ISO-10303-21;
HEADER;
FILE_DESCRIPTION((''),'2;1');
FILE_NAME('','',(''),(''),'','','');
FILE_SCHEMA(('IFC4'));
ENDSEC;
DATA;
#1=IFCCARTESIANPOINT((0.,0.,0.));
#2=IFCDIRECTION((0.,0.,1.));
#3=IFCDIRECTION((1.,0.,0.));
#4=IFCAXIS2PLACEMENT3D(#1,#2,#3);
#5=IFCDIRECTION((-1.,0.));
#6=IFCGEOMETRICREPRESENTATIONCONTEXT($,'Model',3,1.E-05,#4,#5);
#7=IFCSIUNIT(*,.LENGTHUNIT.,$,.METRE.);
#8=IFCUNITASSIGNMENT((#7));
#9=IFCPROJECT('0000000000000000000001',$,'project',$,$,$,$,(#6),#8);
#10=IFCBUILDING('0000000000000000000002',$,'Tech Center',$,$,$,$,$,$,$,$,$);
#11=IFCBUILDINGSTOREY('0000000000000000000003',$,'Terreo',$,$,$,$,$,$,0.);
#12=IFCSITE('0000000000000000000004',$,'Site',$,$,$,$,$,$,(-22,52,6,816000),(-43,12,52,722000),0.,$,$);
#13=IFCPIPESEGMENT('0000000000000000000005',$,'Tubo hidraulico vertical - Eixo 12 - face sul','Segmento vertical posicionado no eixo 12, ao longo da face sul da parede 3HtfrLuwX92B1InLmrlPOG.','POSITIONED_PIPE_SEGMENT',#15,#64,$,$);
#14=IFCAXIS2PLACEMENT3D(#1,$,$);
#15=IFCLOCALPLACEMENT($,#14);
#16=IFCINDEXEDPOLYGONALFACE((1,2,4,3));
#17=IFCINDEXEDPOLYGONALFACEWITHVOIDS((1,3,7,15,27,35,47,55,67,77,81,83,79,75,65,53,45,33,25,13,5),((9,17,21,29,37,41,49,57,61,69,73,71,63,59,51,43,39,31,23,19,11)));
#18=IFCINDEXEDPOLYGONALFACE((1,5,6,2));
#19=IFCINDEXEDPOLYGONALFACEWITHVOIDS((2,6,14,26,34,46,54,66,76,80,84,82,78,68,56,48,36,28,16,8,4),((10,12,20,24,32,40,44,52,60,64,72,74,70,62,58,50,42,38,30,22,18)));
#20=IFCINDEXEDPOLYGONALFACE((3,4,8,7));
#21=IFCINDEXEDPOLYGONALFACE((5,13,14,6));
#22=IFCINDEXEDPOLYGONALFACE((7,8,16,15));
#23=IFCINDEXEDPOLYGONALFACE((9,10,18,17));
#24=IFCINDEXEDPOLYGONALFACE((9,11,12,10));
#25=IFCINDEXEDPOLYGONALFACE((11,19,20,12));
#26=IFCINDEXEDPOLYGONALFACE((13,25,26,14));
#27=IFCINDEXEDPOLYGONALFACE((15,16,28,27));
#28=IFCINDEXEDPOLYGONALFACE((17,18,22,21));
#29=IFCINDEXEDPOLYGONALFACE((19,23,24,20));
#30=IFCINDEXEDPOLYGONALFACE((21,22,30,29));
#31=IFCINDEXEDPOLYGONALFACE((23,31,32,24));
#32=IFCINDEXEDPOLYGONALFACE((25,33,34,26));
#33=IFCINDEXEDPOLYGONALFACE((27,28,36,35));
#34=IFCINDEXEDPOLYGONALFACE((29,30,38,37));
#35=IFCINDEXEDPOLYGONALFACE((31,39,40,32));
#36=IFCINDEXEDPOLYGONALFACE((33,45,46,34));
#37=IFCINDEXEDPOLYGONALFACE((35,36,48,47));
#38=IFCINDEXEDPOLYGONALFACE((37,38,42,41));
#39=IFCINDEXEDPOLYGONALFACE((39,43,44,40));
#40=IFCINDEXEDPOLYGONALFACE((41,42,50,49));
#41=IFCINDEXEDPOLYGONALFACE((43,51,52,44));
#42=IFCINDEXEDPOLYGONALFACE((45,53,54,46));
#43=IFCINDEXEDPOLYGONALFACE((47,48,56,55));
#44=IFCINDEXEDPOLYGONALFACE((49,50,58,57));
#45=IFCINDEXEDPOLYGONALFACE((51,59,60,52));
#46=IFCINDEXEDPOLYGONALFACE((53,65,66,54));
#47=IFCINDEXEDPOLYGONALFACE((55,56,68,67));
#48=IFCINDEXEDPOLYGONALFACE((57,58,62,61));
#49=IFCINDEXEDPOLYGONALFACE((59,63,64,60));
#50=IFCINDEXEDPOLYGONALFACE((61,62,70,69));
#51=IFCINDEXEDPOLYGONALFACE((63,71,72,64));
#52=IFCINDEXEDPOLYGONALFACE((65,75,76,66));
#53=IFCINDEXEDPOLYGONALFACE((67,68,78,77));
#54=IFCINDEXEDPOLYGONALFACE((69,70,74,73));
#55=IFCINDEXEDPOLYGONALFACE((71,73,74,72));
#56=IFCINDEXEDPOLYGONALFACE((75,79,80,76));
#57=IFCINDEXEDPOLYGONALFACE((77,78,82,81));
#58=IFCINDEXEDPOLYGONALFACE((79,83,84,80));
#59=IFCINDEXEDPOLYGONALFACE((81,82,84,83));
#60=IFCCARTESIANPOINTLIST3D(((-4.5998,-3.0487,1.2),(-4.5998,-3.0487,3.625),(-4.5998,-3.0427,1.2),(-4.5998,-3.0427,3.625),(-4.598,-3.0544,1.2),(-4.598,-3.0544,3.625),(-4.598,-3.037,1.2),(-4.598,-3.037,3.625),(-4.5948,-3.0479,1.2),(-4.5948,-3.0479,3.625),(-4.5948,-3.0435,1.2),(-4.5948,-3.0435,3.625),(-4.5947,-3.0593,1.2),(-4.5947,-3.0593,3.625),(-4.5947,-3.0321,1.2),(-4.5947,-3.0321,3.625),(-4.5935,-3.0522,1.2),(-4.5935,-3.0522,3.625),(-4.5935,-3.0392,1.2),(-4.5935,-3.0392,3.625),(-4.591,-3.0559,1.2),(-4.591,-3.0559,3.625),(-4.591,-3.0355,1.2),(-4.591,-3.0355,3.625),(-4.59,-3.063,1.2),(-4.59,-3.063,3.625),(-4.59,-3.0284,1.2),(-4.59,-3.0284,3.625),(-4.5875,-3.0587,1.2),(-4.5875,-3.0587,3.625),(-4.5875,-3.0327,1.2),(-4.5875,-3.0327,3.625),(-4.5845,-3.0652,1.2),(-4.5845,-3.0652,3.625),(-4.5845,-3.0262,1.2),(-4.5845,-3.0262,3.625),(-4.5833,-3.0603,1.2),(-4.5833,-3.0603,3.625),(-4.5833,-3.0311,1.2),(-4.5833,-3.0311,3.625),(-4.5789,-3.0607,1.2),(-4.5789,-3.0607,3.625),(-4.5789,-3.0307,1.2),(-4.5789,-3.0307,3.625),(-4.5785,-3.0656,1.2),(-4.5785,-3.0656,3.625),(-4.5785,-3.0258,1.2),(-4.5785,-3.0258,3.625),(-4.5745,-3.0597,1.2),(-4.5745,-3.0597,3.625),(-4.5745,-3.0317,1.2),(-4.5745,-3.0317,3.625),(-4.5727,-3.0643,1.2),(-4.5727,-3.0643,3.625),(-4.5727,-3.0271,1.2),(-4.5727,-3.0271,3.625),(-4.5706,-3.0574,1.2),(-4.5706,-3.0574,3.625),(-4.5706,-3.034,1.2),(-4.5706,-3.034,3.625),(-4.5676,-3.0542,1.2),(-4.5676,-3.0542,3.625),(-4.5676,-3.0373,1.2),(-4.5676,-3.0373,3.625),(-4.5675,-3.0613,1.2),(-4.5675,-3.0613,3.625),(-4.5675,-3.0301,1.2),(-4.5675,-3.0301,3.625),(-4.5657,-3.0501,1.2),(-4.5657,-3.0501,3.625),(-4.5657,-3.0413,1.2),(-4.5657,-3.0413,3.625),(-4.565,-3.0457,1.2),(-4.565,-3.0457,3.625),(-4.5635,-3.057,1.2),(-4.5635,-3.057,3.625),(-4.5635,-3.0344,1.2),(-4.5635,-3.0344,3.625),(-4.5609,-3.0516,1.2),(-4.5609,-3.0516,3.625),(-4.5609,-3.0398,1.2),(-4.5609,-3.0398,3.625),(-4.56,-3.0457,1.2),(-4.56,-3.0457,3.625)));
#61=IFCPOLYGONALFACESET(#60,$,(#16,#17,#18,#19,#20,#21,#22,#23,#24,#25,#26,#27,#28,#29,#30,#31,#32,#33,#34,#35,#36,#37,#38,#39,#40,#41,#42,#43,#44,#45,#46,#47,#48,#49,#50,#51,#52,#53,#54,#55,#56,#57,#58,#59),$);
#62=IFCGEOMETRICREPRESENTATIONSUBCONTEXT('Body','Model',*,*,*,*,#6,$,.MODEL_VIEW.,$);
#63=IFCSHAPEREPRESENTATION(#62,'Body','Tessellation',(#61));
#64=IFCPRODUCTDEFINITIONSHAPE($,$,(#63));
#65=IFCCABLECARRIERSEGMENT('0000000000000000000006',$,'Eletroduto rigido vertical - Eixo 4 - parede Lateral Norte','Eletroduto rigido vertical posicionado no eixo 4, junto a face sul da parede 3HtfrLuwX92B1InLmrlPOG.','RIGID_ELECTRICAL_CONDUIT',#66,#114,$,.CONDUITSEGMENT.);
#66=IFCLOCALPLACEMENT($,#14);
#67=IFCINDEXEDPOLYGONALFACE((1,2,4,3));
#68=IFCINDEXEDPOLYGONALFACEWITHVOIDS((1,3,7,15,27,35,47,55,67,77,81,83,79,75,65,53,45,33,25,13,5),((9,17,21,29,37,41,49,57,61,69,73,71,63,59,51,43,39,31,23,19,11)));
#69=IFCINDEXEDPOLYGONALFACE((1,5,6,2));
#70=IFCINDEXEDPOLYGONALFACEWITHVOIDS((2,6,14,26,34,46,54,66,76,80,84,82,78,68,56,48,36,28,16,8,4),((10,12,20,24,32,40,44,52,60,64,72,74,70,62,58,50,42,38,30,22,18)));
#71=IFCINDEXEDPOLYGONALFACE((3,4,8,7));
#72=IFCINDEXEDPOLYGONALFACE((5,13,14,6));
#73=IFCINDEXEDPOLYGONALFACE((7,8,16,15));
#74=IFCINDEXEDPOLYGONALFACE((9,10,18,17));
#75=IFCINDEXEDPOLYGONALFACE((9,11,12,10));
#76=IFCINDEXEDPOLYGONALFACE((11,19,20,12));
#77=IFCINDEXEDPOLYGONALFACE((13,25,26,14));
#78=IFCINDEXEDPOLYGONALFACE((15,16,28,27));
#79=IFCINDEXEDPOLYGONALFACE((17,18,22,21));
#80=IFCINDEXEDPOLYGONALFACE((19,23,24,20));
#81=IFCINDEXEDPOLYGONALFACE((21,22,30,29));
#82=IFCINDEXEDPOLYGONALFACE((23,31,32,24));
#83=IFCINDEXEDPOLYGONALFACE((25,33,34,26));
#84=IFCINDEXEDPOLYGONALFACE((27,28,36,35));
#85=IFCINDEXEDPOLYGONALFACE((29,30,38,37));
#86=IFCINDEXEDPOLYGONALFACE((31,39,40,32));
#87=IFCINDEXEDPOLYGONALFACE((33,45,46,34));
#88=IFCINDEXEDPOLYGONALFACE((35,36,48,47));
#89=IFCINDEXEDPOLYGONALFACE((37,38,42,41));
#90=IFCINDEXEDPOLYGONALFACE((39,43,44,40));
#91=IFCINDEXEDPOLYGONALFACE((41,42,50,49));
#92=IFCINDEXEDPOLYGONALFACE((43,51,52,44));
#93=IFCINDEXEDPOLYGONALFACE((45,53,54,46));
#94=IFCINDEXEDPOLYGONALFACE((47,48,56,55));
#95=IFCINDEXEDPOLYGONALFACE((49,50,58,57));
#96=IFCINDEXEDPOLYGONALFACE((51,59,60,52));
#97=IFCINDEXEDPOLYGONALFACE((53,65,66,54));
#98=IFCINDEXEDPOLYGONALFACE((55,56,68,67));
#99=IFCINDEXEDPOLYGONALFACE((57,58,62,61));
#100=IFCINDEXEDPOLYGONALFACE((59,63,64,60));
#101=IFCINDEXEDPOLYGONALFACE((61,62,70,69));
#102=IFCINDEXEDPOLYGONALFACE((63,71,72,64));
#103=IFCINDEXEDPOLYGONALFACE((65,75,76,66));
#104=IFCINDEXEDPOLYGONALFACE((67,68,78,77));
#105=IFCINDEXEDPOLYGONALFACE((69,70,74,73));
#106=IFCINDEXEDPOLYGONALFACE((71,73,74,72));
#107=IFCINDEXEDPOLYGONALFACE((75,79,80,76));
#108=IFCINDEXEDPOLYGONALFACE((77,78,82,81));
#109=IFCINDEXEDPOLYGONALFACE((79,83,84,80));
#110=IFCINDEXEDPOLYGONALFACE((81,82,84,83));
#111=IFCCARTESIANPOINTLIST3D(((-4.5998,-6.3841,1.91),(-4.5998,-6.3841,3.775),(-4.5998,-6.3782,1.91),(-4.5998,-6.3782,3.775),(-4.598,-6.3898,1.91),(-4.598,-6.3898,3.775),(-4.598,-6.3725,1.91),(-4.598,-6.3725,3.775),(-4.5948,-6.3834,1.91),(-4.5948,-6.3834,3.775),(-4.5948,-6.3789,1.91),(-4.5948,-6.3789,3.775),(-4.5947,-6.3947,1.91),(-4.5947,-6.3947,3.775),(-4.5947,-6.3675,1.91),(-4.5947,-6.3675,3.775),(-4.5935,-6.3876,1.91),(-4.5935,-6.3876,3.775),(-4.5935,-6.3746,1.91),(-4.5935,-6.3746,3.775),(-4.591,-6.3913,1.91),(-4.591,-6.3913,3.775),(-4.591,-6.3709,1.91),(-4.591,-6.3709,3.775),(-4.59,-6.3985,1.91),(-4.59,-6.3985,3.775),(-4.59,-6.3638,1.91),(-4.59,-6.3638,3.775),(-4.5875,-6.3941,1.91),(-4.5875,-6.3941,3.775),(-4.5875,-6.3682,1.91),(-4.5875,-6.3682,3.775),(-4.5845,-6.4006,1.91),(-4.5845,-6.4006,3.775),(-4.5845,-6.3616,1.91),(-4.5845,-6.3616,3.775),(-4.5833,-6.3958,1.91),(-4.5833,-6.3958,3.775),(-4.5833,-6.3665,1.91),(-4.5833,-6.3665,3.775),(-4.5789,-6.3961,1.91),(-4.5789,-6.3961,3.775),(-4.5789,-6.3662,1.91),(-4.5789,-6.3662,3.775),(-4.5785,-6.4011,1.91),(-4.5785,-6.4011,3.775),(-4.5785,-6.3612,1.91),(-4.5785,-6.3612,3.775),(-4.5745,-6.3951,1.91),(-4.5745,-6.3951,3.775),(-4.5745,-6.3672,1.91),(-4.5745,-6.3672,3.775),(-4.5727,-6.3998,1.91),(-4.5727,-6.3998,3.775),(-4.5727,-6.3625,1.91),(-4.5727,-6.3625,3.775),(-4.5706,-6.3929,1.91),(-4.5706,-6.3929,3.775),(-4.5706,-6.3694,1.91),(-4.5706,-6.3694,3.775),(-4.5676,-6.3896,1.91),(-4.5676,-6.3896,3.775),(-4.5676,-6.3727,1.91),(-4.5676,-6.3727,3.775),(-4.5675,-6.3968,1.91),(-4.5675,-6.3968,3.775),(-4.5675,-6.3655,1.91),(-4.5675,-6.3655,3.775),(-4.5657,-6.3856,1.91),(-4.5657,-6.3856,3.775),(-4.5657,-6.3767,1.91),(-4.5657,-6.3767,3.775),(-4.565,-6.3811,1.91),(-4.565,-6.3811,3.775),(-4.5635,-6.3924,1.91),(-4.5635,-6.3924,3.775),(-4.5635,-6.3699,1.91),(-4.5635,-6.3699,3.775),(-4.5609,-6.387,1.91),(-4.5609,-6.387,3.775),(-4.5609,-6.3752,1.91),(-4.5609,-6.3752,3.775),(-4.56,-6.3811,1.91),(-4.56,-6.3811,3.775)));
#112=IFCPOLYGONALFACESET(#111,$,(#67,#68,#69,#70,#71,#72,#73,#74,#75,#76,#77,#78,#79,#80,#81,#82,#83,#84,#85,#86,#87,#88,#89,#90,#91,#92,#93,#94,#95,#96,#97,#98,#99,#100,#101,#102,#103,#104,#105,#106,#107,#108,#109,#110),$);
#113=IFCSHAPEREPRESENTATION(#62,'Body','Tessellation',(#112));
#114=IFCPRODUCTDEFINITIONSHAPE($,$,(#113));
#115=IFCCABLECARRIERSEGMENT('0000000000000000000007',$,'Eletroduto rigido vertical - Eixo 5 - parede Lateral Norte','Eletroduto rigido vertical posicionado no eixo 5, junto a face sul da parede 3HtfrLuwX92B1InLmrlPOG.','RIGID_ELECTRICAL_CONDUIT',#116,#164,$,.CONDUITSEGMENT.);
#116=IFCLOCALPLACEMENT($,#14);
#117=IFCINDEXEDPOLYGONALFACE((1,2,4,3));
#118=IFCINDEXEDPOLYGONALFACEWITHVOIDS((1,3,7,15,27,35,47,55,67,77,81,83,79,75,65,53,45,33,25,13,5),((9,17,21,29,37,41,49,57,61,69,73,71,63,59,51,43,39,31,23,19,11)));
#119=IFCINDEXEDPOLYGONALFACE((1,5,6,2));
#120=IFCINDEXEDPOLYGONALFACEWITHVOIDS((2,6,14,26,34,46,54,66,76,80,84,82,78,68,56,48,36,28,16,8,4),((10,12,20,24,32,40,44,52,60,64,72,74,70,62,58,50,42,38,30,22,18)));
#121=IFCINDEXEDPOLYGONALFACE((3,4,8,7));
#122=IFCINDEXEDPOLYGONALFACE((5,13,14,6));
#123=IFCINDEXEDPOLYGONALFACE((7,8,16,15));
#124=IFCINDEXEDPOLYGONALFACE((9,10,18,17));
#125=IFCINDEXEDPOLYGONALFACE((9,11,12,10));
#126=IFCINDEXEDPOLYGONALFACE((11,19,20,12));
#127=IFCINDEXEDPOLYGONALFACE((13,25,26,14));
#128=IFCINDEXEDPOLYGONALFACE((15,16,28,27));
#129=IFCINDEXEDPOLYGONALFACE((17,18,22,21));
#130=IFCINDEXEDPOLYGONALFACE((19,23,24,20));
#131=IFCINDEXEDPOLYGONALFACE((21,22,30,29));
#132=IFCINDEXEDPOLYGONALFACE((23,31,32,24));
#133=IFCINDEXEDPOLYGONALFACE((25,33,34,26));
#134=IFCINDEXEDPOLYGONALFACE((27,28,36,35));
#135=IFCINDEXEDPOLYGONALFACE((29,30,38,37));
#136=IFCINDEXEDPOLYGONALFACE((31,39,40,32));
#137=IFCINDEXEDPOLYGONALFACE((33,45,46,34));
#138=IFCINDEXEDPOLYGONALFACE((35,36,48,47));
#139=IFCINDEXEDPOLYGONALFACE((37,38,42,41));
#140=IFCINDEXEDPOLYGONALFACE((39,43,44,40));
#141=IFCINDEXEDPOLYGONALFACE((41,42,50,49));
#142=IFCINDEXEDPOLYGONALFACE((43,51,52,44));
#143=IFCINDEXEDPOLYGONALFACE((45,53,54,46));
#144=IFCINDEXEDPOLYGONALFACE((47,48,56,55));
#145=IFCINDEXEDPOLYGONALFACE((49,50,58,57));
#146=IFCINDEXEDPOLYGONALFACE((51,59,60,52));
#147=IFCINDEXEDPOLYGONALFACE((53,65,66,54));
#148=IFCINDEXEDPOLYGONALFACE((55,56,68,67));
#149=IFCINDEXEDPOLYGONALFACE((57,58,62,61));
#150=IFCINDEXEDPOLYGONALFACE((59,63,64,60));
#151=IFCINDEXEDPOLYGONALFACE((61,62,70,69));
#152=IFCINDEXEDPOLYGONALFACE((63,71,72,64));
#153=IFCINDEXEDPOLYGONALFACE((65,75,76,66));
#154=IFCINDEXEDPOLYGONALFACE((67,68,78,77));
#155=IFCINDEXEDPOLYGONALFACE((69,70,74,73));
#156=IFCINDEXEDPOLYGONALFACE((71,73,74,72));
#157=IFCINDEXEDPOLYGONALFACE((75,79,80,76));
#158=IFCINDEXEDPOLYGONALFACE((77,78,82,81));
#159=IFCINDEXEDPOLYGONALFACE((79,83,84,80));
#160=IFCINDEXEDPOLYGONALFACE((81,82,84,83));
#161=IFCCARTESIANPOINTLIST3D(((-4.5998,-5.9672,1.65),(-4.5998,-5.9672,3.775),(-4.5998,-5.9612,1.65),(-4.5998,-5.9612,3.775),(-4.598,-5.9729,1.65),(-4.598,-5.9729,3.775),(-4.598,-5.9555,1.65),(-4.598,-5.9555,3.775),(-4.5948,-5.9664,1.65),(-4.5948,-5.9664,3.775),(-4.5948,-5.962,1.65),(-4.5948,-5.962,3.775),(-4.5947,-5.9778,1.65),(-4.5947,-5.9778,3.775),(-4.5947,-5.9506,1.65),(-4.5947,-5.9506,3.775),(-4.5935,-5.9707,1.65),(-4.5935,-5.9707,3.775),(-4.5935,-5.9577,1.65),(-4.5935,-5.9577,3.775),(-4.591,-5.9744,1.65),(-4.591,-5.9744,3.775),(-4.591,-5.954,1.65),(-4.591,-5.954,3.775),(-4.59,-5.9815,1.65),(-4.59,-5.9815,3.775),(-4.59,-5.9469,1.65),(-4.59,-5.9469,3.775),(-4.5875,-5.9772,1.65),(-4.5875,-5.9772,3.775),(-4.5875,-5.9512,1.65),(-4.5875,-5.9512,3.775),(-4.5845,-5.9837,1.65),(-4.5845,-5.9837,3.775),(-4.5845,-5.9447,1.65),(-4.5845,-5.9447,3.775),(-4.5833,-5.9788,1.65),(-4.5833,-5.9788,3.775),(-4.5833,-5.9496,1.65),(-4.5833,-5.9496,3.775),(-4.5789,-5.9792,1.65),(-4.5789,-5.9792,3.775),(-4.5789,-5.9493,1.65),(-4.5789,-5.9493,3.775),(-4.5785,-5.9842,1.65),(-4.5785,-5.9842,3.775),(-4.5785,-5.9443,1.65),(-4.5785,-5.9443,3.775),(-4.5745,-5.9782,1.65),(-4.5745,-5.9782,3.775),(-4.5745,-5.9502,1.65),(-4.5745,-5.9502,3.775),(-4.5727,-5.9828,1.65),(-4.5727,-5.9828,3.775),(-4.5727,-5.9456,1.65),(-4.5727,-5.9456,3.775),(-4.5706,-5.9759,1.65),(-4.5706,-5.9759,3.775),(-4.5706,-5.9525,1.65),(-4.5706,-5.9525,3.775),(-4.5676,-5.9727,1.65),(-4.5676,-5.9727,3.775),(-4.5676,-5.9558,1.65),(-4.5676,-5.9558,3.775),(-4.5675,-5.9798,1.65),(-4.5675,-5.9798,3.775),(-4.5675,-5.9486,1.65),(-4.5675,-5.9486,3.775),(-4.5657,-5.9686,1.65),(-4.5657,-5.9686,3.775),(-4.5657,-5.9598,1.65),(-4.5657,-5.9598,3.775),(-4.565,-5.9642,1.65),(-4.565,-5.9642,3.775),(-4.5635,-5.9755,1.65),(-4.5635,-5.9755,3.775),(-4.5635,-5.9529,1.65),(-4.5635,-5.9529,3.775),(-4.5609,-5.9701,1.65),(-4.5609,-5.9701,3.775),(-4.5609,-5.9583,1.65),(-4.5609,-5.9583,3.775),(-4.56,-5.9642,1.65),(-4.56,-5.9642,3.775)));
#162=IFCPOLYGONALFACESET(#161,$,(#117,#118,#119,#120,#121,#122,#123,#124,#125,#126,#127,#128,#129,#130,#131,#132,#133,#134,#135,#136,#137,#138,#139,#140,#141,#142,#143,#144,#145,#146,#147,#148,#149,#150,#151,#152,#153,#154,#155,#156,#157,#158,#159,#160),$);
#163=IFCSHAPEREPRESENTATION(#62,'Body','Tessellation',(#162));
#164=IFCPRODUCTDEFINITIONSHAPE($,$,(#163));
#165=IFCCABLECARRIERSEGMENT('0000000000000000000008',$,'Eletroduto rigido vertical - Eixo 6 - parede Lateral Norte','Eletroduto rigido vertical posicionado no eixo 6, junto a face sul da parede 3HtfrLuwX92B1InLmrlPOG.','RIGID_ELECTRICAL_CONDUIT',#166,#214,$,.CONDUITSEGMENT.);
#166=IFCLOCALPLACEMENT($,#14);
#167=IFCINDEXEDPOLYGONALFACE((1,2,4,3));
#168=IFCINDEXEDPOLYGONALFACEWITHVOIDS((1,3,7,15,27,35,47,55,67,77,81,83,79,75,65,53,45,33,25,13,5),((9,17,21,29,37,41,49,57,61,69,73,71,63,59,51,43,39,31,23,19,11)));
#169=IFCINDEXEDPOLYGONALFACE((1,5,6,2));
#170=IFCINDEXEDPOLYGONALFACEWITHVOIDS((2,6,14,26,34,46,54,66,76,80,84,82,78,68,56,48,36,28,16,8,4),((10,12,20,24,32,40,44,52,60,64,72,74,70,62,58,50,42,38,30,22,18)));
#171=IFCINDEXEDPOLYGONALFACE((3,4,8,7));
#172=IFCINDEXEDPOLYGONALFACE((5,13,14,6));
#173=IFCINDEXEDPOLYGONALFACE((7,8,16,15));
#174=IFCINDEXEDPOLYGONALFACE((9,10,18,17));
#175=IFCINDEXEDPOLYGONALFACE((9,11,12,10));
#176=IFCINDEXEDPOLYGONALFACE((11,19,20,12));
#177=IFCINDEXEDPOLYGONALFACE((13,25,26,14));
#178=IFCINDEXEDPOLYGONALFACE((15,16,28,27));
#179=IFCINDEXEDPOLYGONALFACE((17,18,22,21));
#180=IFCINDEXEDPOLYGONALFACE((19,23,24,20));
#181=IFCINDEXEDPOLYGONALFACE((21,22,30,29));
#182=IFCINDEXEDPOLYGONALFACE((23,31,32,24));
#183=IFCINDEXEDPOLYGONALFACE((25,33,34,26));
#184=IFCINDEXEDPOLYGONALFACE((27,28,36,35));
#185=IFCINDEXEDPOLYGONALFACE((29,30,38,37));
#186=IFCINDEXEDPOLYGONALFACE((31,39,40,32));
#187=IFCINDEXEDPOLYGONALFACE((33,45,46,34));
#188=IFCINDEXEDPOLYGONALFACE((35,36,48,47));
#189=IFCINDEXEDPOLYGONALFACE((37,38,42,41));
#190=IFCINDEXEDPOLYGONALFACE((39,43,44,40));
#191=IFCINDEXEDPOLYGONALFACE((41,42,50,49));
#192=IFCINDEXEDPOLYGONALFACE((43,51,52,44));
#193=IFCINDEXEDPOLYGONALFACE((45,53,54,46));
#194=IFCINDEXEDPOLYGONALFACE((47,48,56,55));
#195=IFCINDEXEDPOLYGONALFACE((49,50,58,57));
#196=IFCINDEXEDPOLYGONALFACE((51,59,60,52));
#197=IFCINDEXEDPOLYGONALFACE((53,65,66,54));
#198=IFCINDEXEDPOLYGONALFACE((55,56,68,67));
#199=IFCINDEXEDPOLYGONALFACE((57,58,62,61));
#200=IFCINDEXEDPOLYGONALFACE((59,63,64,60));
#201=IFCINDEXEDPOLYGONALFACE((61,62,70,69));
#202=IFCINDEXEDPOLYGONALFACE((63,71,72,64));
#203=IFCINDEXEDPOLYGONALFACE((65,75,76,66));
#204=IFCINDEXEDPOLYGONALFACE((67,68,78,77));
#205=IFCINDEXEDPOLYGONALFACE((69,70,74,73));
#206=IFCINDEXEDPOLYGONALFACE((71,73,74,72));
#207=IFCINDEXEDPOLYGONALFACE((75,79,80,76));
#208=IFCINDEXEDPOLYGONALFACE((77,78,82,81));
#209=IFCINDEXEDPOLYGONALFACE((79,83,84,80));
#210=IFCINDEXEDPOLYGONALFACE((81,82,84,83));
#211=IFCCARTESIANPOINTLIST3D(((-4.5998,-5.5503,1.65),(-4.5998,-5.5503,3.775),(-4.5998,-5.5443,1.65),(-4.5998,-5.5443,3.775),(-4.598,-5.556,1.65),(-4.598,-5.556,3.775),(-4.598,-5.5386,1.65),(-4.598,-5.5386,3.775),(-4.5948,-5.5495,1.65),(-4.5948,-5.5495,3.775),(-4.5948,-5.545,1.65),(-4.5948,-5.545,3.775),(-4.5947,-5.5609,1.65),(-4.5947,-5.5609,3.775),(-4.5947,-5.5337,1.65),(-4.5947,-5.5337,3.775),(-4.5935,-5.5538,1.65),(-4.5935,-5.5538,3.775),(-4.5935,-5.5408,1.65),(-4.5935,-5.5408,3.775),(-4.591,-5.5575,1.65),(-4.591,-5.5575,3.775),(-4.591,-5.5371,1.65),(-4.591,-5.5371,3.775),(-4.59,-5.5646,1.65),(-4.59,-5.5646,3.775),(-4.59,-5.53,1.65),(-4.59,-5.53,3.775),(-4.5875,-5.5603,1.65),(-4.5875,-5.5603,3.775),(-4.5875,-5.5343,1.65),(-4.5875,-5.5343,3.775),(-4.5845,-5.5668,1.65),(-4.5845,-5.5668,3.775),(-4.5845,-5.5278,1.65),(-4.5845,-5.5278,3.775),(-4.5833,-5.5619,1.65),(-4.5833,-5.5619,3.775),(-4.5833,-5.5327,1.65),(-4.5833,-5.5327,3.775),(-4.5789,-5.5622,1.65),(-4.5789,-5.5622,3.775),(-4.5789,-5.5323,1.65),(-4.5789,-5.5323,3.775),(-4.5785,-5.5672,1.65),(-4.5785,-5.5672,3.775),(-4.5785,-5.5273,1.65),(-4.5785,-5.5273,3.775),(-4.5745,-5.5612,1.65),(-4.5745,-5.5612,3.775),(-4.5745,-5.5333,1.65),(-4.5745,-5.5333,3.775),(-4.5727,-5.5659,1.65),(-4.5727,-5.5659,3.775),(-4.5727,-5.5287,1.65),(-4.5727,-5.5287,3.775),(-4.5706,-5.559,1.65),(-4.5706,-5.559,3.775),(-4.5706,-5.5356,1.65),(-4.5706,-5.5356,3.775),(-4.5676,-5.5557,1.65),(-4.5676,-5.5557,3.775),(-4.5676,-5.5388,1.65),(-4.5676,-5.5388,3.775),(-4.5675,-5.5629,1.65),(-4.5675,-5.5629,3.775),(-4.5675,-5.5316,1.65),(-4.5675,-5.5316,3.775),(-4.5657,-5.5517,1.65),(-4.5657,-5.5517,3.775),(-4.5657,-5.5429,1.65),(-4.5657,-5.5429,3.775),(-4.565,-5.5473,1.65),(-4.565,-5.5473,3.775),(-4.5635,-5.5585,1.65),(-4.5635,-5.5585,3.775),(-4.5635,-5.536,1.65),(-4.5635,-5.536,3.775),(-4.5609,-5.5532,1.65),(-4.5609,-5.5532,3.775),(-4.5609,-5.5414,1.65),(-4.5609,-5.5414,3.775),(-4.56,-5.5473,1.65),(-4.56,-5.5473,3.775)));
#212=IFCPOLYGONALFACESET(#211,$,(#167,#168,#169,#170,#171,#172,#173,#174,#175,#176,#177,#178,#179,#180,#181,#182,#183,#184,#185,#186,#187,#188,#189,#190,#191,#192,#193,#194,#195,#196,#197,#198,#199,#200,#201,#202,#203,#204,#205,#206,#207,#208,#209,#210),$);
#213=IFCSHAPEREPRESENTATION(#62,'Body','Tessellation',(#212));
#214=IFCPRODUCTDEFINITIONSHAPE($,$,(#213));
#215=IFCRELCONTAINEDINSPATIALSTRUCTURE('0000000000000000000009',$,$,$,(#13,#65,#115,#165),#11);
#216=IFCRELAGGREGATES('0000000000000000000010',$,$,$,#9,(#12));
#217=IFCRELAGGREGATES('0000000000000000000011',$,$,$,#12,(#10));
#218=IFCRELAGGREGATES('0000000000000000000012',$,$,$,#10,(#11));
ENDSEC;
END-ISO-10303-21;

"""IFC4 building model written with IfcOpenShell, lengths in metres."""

from ifc_helpers import new_model, si_unit, direction, frame, origin_with_axes, place, context, subcontext, project, spatial, hollow_circle, extrude, element, save


model = new_model("IFC4")

# Units and contexts
model_context = context("Model", 3, precision=1e-05, world=origin_with_axes(), true_north=direction((-1.0, 0.0)))
body_context = subcontext(model_context, "Body", "Model", "MODEL_VIEW")
ifc_project = project(units=[si_unit("LENGTHUNIT", "METRE")], contexts=[model_context])

# Site, building, storey
site = spatial("IfcSite", under=ifc_project, Name="Site", RefLatitude=(-22, 52, 6, 816000), RefLongitude=(-43, 12, 52, 722000), RefElevation=0.0)
building = spatial("IfcBuilding", under=site, Name="Tech Center")
storey = spatial("IfcBuildingStorey", under=building, Name="Terreo", Elevation=0.0)

# Pipe segment
for number, where, name in (
    (1, (-4.58, -3.0457, 1.2), "Tubo hidraulico vertical - Eixo 12 - face sul"),
):
    element("IfcPipeSegment", number, at=place(None, frame(where)), inside=storey, Name=name, Description="Segmento vertical posicionado no eixo 12, ao longo da face sul da parede 3HtfrLuwX92B1InLmrlPOG.", ObjectType="POSITIONED_PIPE_SEGMENT", context=body_context, shape_type="SweptSolid", body=[
        extrude(hollow_circle(Radius=0.02, WallThickness=0.005), origin_with_axes(), (0.0, 0.0, 1.0), 2.425),
    ])

# Cable carrier segments
cable_carrier_segment_1_placement = place(None, frame((-4.58, -6.3811, 1.91)))
element("IfcCableCarrierSegment", 2, at=cable_carrier_segment_1_placement, inside=storey, Name="Eletroduto rigido vertical - Eixo 4 - parede Lateral Norte", Description="Eletroduto rigido vertical posicionado no eixo 4, junto a face sul da parede 3HtfrLuwX92B1InLmrlPOG.", ObjectType="RIGID_ELECTRICAL_CONDUIT", PredefinedType="CONDUITSEGMENT", context=body_context, shape_type="SweptSolid", body=[
    extrude(hollow_circle(Radius=0.02, WallThickness=0.005), origin_with_axes(), (0.0, 0.0, 1.0), 1.865),
])
for number, where, name, description in (
    (3, (-4.58, -5.9642, 1.65), "Eletroduto rigido vertical - Eixo 5 - parede Lateral Norte", "Eletroduto rigido vertical posicionado no eixo 5, junto a face sul da parede 3HtfrLuwX92B1InLmrlPOG."),
    (4, (-4.58, -5.5473, 1.65), "Eletroduto rigido vertical - Eixo 6 - parede Lateral Norte", "Eletroduto rigido vertical posicionado no eixo 6, junto a face sul da parede 3HtfrLuwX92B1InLmrlPOG."),
):
    element("IfcCableCarrierSegment", number, at=place(None, frame(where)), inside=storey, Name=name, Description=description, ObjectType="RIGID_ELECTRICAL_CONDUIT", PredefinedType="CONDUITSEGMENT", context=body_context, shape_type="SweptSolid", body=[
        extrude(hollow_circle(Radius=0.02, WallThickness=0.005), origin_with_axes(), (0.0, 0.0, 1.0), 2.125),
    ])

save(model, "model.ifc")
